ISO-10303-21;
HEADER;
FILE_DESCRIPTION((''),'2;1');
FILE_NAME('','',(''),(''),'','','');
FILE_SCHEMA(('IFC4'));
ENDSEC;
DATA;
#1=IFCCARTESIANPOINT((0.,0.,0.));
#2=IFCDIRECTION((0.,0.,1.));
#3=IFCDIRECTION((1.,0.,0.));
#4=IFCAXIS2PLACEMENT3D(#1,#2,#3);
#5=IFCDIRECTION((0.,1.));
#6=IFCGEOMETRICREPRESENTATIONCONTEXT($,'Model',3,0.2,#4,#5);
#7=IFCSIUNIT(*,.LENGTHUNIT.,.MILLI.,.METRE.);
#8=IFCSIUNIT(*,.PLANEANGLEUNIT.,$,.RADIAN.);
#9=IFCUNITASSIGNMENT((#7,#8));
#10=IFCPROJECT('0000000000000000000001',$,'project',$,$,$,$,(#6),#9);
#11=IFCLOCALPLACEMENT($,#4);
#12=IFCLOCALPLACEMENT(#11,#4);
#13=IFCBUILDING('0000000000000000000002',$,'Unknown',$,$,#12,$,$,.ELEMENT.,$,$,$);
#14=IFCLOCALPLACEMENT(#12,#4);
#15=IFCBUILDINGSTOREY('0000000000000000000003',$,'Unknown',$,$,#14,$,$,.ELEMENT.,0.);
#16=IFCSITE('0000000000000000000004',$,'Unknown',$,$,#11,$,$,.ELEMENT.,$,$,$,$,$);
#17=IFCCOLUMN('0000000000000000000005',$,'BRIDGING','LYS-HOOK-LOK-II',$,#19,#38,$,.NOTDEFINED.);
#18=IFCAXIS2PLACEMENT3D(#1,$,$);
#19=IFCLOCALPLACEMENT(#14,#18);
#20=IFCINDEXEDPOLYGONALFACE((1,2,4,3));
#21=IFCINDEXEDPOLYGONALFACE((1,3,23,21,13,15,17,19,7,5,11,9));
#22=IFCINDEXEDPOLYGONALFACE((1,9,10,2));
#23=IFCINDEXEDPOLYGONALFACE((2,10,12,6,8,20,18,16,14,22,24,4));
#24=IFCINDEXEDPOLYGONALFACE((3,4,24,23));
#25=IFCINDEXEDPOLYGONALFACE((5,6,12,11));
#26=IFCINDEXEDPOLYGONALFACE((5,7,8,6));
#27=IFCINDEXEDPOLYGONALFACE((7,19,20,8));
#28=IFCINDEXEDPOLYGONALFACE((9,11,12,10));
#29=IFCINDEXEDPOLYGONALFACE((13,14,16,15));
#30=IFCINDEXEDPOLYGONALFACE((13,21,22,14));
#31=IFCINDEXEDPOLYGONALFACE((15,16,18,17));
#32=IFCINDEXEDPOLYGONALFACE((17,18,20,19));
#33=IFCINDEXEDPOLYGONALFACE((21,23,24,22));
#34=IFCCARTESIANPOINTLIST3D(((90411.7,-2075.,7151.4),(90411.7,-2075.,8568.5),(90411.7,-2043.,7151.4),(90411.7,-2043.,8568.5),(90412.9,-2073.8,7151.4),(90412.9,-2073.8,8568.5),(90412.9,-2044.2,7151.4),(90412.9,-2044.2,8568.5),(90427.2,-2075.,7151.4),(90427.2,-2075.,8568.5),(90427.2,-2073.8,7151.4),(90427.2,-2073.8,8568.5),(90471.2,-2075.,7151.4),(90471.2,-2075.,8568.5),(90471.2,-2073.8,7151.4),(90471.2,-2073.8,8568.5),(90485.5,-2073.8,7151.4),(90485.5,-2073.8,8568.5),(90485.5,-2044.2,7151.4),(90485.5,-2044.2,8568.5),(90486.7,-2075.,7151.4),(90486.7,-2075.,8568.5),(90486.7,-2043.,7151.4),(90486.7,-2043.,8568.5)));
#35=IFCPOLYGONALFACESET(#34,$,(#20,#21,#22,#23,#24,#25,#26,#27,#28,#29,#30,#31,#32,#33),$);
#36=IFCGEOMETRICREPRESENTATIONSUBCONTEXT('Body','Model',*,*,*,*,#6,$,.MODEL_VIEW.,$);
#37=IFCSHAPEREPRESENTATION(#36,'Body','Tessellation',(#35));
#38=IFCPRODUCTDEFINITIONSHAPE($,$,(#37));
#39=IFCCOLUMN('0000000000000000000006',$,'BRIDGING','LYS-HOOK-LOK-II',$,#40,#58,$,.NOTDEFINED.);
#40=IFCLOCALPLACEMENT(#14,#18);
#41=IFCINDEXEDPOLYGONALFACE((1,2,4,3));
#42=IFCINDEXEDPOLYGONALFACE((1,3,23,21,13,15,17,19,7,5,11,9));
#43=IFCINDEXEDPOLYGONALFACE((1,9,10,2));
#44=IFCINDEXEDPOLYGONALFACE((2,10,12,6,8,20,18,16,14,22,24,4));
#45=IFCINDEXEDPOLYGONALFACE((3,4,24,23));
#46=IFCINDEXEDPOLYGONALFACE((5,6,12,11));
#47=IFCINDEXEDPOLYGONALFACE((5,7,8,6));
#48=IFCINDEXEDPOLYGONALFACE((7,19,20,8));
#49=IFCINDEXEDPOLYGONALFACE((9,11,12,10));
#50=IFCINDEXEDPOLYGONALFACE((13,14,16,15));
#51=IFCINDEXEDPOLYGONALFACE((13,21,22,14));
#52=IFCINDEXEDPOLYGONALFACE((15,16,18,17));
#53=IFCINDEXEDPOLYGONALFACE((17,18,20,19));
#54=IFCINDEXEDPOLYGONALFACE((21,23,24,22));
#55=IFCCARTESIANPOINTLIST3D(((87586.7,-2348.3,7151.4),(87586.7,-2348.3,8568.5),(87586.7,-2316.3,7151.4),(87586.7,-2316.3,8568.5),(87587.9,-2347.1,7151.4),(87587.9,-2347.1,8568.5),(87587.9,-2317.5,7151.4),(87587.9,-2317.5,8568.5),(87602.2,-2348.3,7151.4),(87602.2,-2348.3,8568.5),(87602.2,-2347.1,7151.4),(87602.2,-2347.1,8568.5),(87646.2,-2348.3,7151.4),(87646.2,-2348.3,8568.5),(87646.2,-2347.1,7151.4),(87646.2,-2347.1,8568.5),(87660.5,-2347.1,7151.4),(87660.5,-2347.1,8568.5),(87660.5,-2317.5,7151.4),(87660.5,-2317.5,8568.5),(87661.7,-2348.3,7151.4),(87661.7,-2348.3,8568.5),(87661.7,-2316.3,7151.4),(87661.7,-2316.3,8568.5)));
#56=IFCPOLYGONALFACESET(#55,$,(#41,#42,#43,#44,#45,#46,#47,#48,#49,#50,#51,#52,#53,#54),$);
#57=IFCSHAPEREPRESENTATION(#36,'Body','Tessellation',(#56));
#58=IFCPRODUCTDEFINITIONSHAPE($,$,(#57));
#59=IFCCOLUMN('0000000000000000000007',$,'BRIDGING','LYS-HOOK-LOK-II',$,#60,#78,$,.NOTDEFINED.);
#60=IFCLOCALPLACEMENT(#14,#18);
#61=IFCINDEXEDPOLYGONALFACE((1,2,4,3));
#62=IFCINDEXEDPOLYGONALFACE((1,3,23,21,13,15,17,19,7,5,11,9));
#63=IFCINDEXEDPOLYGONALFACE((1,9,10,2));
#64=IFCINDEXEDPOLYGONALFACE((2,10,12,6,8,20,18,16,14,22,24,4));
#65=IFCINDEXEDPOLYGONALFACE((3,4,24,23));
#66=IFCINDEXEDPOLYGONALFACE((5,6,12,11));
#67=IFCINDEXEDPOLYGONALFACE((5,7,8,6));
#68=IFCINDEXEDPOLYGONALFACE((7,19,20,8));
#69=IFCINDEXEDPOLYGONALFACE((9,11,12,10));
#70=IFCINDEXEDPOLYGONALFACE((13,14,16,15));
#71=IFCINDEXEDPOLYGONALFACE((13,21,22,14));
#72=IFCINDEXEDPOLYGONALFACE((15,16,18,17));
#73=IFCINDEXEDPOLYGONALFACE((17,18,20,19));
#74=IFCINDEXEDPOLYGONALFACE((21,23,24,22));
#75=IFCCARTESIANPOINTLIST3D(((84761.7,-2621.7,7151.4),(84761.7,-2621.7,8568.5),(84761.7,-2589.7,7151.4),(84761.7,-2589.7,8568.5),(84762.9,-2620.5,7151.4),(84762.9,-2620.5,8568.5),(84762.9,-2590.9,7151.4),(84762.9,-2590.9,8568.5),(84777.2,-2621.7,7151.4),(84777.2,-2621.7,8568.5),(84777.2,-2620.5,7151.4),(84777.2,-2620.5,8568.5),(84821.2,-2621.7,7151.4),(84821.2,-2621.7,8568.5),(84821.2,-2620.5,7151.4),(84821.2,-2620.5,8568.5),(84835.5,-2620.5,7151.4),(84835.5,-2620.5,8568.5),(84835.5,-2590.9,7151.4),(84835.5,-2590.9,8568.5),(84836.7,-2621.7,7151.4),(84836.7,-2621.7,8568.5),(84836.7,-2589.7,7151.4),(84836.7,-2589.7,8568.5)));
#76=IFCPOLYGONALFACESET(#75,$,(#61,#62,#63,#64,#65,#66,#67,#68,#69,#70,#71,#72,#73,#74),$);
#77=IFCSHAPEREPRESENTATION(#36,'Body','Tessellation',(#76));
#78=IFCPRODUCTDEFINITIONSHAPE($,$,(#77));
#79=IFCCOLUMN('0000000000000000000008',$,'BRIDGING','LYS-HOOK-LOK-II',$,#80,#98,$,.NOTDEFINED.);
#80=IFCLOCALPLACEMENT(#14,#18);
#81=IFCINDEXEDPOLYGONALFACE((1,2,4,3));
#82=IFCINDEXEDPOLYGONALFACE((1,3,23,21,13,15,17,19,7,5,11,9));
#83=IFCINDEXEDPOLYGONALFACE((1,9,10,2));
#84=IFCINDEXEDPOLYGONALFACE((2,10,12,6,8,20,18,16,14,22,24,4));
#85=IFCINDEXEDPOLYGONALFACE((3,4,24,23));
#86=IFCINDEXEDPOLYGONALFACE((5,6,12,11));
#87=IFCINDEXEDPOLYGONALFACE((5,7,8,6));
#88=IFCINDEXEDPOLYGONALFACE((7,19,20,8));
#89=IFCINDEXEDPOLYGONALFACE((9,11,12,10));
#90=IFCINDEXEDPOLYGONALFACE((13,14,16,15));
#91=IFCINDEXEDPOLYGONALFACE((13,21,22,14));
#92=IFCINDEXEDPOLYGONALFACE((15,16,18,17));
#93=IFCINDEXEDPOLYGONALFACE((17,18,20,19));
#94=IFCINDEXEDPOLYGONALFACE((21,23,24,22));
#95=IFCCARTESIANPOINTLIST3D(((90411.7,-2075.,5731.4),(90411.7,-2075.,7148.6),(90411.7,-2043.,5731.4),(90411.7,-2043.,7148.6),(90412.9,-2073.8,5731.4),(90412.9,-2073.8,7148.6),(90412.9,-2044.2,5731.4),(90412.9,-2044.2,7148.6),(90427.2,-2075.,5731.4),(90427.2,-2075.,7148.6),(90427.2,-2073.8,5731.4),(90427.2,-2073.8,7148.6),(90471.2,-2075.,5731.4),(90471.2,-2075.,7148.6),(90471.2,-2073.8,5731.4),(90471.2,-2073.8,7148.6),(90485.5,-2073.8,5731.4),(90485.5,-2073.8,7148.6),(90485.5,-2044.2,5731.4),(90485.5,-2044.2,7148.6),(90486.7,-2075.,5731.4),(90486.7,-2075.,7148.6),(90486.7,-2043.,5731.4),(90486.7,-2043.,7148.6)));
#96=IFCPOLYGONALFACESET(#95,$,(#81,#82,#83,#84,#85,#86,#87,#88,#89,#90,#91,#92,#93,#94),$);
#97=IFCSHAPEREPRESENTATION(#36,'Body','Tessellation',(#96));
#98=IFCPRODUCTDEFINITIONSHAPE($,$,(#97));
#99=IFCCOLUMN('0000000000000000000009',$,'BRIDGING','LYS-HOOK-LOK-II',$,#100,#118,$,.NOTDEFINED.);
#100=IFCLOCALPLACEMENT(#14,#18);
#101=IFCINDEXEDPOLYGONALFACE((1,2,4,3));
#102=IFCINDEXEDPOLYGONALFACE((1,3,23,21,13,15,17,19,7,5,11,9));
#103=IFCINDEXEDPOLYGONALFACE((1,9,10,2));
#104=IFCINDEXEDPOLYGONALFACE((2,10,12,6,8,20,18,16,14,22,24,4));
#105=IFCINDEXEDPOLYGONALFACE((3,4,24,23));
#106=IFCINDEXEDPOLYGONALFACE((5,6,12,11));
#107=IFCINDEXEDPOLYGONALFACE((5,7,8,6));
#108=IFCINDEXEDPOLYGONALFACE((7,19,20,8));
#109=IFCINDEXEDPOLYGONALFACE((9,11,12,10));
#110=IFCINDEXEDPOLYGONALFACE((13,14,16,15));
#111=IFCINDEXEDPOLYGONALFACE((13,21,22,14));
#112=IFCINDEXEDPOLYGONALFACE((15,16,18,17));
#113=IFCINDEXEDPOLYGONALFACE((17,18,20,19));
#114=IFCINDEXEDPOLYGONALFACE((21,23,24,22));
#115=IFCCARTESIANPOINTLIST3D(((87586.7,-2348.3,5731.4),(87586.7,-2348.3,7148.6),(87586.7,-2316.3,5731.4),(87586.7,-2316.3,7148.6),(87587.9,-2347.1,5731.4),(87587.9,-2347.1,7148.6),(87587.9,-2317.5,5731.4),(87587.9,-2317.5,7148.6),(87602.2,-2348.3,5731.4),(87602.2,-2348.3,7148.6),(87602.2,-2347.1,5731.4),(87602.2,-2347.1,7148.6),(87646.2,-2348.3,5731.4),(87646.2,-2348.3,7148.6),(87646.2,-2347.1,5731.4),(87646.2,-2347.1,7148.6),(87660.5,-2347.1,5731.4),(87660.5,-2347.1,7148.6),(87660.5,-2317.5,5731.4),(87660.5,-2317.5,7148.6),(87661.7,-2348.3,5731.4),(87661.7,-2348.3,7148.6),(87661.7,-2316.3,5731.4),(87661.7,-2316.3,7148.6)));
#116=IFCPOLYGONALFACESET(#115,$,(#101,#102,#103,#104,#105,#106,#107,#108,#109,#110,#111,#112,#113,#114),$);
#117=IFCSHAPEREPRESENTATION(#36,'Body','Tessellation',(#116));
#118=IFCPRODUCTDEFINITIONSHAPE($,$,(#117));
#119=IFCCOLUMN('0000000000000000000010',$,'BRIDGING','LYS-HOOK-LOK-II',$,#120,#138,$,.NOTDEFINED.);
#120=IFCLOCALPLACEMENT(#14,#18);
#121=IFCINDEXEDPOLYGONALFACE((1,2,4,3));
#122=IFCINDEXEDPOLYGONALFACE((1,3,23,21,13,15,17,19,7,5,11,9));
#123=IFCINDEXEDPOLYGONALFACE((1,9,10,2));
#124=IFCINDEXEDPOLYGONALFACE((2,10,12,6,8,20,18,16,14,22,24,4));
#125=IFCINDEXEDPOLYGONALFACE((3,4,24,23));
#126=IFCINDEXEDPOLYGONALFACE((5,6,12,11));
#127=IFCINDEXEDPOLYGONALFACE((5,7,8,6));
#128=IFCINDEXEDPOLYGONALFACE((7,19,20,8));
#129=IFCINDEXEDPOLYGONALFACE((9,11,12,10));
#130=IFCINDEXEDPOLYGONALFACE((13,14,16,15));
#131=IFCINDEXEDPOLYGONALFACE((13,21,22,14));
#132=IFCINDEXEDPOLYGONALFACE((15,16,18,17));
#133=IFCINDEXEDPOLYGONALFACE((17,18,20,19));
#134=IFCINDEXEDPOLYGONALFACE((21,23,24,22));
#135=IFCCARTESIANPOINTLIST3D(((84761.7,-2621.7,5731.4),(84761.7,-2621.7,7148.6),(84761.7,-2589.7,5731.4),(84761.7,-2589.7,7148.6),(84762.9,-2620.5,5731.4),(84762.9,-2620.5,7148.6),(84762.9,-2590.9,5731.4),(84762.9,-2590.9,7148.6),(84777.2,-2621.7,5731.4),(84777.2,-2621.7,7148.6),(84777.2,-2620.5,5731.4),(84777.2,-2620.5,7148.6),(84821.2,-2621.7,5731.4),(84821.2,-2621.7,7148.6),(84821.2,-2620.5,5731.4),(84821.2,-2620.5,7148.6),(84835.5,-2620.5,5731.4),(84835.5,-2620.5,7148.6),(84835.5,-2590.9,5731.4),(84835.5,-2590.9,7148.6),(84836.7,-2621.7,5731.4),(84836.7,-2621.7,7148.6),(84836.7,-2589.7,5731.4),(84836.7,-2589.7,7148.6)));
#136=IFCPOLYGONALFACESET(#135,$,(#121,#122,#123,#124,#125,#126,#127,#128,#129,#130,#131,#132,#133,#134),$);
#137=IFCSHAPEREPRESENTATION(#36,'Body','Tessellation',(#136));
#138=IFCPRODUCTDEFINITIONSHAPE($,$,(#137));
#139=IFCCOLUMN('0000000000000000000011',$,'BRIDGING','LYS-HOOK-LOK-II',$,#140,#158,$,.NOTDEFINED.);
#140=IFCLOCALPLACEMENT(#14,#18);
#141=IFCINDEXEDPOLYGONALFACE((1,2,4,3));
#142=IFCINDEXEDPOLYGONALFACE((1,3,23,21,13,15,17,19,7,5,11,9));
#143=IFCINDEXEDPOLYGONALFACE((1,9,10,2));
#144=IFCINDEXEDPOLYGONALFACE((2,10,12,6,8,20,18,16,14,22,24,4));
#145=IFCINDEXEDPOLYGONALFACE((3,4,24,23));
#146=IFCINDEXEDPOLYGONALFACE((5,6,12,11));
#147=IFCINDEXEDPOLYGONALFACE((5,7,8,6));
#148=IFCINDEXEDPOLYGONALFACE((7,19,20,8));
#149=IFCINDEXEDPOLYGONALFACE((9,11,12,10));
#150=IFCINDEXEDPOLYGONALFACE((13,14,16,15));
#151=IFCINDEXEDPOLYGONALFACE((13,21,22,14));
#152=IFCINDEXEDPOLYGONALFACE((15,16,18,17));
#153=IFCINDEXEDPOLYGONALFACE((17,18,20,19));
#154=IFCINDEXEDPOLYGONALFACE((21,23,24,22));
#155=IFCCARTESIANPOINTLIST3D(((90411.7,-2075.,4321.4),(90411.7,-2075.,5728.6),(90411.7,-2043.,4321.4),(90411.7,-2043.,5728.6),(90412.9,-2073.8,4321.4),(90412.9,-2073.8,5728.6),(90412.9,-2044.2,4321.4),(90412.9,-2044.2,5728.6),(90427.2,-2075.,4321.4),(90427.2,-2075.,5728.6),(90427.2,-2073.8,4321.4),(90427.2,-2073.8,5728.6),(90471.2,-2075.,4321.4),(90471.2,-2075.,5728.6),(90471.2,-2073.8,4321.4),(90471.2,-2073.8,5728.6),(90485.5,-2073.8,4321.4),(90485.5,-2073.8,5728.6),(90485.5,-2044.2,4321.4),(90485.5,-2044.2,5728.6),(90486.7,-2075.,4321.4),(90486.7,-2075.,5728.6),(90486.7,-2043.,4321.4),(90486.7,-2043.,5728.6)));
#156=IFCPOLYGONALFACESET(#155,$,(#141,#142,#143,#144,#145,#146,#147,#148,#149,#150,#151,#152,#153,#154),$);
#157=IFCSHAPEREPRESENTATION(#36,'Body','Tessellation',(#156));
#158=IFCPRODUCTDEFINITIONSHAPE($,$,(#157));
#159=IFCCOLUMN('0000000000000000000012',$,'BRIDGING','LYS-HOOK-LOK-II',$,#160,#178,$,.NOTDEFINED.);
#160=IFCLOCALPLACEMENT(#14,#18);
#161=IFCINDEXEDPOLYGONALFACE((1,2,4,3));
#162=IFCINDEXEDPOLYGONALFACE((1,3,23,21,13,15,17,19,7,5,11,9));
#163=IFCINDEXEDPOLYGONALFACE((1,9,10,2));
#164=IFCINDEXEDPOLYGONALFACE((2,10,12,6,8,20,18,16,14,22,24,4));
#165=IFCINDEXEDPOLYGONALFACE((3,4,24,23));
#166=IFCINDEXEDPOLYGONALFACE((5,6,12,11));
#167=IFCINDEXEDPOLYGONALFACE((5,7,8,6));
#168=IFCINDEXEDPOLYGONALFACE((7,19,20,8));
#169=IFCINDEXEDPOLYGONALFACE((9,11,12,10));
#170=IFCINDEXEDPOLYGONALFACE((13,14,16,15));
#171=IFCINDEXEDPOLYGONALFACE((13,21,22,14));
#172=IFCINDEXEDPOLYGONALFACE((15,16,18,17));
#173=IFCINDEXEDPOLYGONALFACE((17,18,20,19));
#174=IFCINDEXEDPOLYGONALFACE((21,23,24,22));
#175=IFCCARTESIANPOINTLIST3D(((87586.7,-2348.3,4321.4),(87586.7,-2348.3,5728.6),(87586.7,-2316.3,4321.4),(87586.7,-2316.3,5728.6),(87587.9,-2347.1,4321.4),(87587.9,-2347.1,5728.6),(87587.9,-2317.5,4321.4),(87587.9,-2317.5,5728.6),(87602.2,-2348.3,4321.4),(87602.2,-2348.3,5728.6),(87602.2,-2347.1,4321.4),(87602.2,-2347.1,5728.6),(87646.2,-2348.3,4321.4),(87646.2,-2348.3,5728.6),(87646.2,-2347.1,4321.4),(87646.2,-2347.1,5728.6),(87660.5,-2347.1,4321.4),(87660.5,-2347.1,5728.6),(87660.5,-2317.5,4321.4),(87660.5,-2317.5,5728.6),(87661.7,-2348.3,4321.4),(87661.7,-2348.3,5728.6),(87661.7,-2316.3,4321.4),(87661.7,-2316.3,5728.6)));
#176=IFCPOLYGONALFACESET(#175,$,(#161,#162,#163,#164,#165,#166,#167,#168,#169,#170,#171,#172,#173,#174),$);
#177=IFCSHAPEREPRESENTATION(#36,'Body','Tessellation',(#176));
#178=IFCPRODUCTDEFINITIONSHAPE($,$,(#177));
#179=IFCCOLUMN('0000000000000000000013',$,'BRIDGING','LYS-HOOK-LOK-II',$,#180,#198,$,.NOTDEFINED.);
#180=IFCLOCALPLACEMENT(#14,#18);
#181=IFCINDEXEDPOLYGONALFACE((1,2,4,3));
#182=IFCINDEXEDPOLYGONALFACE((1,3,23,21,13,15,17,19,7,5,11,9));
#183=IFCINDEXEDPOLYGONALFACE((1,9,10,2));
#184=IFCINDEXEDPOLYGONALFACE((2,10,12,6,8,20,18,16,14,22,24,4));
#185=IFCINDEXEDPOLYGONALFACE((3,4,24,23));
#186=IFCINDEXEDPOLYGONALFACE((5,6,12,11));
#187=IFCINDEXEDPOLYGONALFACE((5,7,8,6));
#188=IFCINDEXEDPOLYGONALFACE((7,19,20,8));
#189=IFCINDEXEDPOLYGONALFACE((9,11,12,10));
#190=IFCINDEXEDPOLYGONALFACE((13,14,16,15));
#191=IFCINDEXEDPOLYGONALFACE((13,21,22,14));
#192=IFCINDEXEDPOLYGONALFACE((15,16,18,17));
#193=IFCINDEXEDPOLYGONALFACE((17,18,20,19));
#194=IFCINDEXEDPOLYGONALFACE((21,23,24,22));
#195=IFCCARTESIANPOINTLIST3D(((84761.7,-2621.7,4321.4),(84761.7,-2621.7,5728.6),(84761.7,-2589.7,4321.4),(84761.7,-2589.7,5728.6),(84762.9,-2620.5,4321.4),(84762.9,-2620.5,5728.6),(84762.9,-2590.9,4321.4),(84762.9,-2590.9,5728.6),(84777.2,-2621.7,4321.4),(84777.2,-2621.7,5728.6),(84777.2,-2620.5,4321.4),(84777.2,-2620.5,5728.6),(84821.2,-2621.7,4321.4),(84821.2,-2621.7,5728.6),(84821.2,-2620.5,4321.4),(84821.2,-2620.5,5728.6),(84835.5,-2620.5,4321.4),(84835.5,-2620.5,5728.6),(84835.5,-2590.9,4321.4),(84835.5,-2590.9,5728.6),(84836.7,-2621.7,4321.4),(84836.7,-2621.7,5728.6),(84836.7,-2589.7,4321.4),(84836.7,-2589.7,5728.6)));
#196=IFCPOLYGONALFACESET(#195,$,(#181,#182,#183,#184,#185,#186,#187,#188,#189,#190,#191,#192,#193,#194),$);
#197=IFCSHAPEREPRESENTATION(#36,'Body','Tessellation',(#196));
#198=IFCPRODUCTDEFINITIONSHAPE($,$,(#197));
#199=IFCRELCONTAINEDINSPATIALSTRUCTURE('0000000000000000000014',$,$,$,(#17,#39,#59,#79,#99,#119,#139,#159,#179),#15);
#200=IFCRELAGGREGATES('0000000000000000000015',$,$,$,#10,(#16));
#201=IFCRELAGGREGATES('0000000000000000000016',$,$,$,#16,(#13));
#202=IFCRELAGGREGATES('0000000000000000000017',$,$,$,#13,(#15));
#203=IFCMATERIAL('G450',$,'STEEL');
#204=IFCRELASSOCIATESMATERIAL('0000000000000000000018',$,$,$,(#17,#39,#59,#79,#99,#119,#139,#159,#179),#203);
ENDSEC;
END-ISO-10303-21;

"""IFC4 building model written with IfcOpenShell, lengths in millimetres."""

from ifc_helpers import new_model, si_unit, direction, frame, origin_with_axes, place, context, subcontext, project, spatial, line, indexed_curve, outline, extrude, material, element, save


model = new_model("IFC4")

# Units and contexts
model_context = context("Model", 3, precision=0.2, world=origin_with_axes(), true_north=direction((0.0, 1.0)))
body_context = subcontext(model_context, "Body", "Model", "MODEL_VIEW")
ifc_project = project(units=[si_unit("LENGTHUNIT", "METRE", prefix="MILLI"), si_unit("PLANEANGLEUNIT", "RADIAN")], contexts=[model_context])

# Site, building, storey
site_placement = place(None, origin_with_axes())
site = spatial("IfcSite", under=ifc_project, at=site_placement, Name="Unknown", CompositionType="ELEMENT")
building_placement = place(site_placement, origin_with_axes())
building = spatial("IfcBuilding", under=site, at=building_placement, Name="Unknown", CompositionType="ELEMENT")
storey_placement = place(building_placement, origin_with_axes())
storey = spatial("IfcBuildingStorey", under=building, at=storey_placement, Name="Unknown", CompositionType="ELEMENT", Elevation=0.0)

# Columns
ifc_material_1 = material(Name="G450", Category="STEEL")
for number, where, z_axis, x_axis, name in (
    (1, (90449.2, -2059.0, 7151.4), (0.0, -1.0, 0.0), (0.0, 0.0, 1.0), "BRIDGING"),
    (2, (87624.2, -2332.3, 7151.4), (0.0, -1.0, 0.0), (0.0, 0.0, 1.0), "BRIDGING"),
    (3, (84799.2, -2605.7, 7151.4), (0.0, -1.0, 0.0), (0.0, 0.0, 1.0), "BRIDGING"),
):
    element("IfcColumn", number, at=place(storey_placement, frame(where, z_axis=z_axis, x_axis=x_axis)), inside=storey, material=ifc_material_1, Name=name, Description="LYS-HOOK-LOK-II", PredefinedType="NOTDEFINED", context=body_context, shape_type="SolidModel", body=[
        extrude(outline(indexed_curve([(16.0, -37.5), (16.0, -22.0), (14.8, -22.0), (14.8, -36.3), (-14.8, -36.3), (-14.8, 36.3), (14.8, 36.3), (14.8, 22.0), (16.0, 22.0), (16.0, 37.5), (-16.0, 37.5), (-16.0, -37.5)], segments=[line(1, 2, 3, 4, 5, 6, 7, 8, 9, 10, 11, 12, 1)])), frame((0.0, 0.0, 0.0), z_axis=(-1.0, 0.0, 0.0), x_axis=(0.0, 0.0, 1.0)), (0.0, 0.0, -1.0), 1417.1),
    ])
for number, where, z_axis, x_axis, name in (
    (4, (90449.2, -2059.0, 5731.4), (0.0, -1.0, 0.0), (0.0, 0.0, 1.0), "BRIDGING"),
    (5, (87624.2, -2332.3, 5731.4), (0.0, -1.0, 0.0), (0.0, 0.0, 1.0), "BRIDGING"),
    (6, (84799.2, -2605.7, 5731.4), (0.0, -1.0, 0.0), (0.0, 0.0, 1.0), "BRIDGING"),
):
    element("IfcColumn", number, at=place(storey_placement, frame(where, z_axis=z_axis, x_axis=x_axis)), inside=storey, material=ifc_material_1, Name=name, Description="LYS-HOOK-LOK-II", PredefinedType="NOTDEFINED", context=body_context, shape_type="SolidModel", body=[
        extrude(outline(indexed_curve([(16.0, -37.5), (16.0, -22.0), (14.8, -22.0), (14.8, -36.3), (-14.8, -36.3), (-14.8, 36.3), (14.8, 36.3), (14.8, 22.0), (16.0, 22.0), (16.0, 37.5), (-16.0, 37.5), (-16.0, -37.5)], segments=[line(1, 2, 3, 4, 5, 6, 7, 8, 9, 10, 11, 12, 1)])), frame((0.0, 0.0, 0.0), z_axis=(-1.0, 0.0, 0.0), x_axis=(0.0, 0.0, 1.0)), (0.0, 0.0, -1.0), 1417.2),
    ])
for number, where, z_axis, x_axis, name in (
    (7, (90449.2, -2059.0, 4321.4), (0.0, -1.0, 0.0), (0.0, 0.0, 1.0), "BRIDGING"),
    (8, (87624.2, -2332.3, 4321.4), (0.0, -1.0, 0.0), (0.0, 0.0, 1.0), "BRIDGING"),
    (9, (84799.2, -2605.7, 4321.4), (0.0, -1.0, 0.0), (0.0, 0.0, 1.0), "BRIDGING"),
):
    element("IfcColumn", number, at=place(storey_placement, frame(where, z_axis=z_axis, x_axis=x_axis)), inside=storey, material=ifc_material_1, Name=name, Description="LYS-HOOK-LOK-II", PredefinedType="NOTDEFINED", context=body_context, shape_type="SolidModel", body=[
        extrude(outline(indexed_curve([(16.0, -37.5), (16.0, -22.0), (14.8, -22.0), (14.8, -36.3), (-14.8, -36.3), (-14.8, 36.3), (14.8, 36.3), (14.8, 22.0), (16.0, 22.0), (16.0, 37.5), (-16.0, 37.5), (-16.0, -37.5)], segments=[line(1, 2, 3, 4, 5, 6, 7, 8, 9, 10, 11, 12, 1)])), frame((0.0, 0.0, 0.0), z_axis=(-1.0, 0.0, 0.0), x_axis=(0.0, 0.0, 1.0)), (0.0, 0.0, -1.0), 1407.2),
    ])

save(model, "model.ifc")
